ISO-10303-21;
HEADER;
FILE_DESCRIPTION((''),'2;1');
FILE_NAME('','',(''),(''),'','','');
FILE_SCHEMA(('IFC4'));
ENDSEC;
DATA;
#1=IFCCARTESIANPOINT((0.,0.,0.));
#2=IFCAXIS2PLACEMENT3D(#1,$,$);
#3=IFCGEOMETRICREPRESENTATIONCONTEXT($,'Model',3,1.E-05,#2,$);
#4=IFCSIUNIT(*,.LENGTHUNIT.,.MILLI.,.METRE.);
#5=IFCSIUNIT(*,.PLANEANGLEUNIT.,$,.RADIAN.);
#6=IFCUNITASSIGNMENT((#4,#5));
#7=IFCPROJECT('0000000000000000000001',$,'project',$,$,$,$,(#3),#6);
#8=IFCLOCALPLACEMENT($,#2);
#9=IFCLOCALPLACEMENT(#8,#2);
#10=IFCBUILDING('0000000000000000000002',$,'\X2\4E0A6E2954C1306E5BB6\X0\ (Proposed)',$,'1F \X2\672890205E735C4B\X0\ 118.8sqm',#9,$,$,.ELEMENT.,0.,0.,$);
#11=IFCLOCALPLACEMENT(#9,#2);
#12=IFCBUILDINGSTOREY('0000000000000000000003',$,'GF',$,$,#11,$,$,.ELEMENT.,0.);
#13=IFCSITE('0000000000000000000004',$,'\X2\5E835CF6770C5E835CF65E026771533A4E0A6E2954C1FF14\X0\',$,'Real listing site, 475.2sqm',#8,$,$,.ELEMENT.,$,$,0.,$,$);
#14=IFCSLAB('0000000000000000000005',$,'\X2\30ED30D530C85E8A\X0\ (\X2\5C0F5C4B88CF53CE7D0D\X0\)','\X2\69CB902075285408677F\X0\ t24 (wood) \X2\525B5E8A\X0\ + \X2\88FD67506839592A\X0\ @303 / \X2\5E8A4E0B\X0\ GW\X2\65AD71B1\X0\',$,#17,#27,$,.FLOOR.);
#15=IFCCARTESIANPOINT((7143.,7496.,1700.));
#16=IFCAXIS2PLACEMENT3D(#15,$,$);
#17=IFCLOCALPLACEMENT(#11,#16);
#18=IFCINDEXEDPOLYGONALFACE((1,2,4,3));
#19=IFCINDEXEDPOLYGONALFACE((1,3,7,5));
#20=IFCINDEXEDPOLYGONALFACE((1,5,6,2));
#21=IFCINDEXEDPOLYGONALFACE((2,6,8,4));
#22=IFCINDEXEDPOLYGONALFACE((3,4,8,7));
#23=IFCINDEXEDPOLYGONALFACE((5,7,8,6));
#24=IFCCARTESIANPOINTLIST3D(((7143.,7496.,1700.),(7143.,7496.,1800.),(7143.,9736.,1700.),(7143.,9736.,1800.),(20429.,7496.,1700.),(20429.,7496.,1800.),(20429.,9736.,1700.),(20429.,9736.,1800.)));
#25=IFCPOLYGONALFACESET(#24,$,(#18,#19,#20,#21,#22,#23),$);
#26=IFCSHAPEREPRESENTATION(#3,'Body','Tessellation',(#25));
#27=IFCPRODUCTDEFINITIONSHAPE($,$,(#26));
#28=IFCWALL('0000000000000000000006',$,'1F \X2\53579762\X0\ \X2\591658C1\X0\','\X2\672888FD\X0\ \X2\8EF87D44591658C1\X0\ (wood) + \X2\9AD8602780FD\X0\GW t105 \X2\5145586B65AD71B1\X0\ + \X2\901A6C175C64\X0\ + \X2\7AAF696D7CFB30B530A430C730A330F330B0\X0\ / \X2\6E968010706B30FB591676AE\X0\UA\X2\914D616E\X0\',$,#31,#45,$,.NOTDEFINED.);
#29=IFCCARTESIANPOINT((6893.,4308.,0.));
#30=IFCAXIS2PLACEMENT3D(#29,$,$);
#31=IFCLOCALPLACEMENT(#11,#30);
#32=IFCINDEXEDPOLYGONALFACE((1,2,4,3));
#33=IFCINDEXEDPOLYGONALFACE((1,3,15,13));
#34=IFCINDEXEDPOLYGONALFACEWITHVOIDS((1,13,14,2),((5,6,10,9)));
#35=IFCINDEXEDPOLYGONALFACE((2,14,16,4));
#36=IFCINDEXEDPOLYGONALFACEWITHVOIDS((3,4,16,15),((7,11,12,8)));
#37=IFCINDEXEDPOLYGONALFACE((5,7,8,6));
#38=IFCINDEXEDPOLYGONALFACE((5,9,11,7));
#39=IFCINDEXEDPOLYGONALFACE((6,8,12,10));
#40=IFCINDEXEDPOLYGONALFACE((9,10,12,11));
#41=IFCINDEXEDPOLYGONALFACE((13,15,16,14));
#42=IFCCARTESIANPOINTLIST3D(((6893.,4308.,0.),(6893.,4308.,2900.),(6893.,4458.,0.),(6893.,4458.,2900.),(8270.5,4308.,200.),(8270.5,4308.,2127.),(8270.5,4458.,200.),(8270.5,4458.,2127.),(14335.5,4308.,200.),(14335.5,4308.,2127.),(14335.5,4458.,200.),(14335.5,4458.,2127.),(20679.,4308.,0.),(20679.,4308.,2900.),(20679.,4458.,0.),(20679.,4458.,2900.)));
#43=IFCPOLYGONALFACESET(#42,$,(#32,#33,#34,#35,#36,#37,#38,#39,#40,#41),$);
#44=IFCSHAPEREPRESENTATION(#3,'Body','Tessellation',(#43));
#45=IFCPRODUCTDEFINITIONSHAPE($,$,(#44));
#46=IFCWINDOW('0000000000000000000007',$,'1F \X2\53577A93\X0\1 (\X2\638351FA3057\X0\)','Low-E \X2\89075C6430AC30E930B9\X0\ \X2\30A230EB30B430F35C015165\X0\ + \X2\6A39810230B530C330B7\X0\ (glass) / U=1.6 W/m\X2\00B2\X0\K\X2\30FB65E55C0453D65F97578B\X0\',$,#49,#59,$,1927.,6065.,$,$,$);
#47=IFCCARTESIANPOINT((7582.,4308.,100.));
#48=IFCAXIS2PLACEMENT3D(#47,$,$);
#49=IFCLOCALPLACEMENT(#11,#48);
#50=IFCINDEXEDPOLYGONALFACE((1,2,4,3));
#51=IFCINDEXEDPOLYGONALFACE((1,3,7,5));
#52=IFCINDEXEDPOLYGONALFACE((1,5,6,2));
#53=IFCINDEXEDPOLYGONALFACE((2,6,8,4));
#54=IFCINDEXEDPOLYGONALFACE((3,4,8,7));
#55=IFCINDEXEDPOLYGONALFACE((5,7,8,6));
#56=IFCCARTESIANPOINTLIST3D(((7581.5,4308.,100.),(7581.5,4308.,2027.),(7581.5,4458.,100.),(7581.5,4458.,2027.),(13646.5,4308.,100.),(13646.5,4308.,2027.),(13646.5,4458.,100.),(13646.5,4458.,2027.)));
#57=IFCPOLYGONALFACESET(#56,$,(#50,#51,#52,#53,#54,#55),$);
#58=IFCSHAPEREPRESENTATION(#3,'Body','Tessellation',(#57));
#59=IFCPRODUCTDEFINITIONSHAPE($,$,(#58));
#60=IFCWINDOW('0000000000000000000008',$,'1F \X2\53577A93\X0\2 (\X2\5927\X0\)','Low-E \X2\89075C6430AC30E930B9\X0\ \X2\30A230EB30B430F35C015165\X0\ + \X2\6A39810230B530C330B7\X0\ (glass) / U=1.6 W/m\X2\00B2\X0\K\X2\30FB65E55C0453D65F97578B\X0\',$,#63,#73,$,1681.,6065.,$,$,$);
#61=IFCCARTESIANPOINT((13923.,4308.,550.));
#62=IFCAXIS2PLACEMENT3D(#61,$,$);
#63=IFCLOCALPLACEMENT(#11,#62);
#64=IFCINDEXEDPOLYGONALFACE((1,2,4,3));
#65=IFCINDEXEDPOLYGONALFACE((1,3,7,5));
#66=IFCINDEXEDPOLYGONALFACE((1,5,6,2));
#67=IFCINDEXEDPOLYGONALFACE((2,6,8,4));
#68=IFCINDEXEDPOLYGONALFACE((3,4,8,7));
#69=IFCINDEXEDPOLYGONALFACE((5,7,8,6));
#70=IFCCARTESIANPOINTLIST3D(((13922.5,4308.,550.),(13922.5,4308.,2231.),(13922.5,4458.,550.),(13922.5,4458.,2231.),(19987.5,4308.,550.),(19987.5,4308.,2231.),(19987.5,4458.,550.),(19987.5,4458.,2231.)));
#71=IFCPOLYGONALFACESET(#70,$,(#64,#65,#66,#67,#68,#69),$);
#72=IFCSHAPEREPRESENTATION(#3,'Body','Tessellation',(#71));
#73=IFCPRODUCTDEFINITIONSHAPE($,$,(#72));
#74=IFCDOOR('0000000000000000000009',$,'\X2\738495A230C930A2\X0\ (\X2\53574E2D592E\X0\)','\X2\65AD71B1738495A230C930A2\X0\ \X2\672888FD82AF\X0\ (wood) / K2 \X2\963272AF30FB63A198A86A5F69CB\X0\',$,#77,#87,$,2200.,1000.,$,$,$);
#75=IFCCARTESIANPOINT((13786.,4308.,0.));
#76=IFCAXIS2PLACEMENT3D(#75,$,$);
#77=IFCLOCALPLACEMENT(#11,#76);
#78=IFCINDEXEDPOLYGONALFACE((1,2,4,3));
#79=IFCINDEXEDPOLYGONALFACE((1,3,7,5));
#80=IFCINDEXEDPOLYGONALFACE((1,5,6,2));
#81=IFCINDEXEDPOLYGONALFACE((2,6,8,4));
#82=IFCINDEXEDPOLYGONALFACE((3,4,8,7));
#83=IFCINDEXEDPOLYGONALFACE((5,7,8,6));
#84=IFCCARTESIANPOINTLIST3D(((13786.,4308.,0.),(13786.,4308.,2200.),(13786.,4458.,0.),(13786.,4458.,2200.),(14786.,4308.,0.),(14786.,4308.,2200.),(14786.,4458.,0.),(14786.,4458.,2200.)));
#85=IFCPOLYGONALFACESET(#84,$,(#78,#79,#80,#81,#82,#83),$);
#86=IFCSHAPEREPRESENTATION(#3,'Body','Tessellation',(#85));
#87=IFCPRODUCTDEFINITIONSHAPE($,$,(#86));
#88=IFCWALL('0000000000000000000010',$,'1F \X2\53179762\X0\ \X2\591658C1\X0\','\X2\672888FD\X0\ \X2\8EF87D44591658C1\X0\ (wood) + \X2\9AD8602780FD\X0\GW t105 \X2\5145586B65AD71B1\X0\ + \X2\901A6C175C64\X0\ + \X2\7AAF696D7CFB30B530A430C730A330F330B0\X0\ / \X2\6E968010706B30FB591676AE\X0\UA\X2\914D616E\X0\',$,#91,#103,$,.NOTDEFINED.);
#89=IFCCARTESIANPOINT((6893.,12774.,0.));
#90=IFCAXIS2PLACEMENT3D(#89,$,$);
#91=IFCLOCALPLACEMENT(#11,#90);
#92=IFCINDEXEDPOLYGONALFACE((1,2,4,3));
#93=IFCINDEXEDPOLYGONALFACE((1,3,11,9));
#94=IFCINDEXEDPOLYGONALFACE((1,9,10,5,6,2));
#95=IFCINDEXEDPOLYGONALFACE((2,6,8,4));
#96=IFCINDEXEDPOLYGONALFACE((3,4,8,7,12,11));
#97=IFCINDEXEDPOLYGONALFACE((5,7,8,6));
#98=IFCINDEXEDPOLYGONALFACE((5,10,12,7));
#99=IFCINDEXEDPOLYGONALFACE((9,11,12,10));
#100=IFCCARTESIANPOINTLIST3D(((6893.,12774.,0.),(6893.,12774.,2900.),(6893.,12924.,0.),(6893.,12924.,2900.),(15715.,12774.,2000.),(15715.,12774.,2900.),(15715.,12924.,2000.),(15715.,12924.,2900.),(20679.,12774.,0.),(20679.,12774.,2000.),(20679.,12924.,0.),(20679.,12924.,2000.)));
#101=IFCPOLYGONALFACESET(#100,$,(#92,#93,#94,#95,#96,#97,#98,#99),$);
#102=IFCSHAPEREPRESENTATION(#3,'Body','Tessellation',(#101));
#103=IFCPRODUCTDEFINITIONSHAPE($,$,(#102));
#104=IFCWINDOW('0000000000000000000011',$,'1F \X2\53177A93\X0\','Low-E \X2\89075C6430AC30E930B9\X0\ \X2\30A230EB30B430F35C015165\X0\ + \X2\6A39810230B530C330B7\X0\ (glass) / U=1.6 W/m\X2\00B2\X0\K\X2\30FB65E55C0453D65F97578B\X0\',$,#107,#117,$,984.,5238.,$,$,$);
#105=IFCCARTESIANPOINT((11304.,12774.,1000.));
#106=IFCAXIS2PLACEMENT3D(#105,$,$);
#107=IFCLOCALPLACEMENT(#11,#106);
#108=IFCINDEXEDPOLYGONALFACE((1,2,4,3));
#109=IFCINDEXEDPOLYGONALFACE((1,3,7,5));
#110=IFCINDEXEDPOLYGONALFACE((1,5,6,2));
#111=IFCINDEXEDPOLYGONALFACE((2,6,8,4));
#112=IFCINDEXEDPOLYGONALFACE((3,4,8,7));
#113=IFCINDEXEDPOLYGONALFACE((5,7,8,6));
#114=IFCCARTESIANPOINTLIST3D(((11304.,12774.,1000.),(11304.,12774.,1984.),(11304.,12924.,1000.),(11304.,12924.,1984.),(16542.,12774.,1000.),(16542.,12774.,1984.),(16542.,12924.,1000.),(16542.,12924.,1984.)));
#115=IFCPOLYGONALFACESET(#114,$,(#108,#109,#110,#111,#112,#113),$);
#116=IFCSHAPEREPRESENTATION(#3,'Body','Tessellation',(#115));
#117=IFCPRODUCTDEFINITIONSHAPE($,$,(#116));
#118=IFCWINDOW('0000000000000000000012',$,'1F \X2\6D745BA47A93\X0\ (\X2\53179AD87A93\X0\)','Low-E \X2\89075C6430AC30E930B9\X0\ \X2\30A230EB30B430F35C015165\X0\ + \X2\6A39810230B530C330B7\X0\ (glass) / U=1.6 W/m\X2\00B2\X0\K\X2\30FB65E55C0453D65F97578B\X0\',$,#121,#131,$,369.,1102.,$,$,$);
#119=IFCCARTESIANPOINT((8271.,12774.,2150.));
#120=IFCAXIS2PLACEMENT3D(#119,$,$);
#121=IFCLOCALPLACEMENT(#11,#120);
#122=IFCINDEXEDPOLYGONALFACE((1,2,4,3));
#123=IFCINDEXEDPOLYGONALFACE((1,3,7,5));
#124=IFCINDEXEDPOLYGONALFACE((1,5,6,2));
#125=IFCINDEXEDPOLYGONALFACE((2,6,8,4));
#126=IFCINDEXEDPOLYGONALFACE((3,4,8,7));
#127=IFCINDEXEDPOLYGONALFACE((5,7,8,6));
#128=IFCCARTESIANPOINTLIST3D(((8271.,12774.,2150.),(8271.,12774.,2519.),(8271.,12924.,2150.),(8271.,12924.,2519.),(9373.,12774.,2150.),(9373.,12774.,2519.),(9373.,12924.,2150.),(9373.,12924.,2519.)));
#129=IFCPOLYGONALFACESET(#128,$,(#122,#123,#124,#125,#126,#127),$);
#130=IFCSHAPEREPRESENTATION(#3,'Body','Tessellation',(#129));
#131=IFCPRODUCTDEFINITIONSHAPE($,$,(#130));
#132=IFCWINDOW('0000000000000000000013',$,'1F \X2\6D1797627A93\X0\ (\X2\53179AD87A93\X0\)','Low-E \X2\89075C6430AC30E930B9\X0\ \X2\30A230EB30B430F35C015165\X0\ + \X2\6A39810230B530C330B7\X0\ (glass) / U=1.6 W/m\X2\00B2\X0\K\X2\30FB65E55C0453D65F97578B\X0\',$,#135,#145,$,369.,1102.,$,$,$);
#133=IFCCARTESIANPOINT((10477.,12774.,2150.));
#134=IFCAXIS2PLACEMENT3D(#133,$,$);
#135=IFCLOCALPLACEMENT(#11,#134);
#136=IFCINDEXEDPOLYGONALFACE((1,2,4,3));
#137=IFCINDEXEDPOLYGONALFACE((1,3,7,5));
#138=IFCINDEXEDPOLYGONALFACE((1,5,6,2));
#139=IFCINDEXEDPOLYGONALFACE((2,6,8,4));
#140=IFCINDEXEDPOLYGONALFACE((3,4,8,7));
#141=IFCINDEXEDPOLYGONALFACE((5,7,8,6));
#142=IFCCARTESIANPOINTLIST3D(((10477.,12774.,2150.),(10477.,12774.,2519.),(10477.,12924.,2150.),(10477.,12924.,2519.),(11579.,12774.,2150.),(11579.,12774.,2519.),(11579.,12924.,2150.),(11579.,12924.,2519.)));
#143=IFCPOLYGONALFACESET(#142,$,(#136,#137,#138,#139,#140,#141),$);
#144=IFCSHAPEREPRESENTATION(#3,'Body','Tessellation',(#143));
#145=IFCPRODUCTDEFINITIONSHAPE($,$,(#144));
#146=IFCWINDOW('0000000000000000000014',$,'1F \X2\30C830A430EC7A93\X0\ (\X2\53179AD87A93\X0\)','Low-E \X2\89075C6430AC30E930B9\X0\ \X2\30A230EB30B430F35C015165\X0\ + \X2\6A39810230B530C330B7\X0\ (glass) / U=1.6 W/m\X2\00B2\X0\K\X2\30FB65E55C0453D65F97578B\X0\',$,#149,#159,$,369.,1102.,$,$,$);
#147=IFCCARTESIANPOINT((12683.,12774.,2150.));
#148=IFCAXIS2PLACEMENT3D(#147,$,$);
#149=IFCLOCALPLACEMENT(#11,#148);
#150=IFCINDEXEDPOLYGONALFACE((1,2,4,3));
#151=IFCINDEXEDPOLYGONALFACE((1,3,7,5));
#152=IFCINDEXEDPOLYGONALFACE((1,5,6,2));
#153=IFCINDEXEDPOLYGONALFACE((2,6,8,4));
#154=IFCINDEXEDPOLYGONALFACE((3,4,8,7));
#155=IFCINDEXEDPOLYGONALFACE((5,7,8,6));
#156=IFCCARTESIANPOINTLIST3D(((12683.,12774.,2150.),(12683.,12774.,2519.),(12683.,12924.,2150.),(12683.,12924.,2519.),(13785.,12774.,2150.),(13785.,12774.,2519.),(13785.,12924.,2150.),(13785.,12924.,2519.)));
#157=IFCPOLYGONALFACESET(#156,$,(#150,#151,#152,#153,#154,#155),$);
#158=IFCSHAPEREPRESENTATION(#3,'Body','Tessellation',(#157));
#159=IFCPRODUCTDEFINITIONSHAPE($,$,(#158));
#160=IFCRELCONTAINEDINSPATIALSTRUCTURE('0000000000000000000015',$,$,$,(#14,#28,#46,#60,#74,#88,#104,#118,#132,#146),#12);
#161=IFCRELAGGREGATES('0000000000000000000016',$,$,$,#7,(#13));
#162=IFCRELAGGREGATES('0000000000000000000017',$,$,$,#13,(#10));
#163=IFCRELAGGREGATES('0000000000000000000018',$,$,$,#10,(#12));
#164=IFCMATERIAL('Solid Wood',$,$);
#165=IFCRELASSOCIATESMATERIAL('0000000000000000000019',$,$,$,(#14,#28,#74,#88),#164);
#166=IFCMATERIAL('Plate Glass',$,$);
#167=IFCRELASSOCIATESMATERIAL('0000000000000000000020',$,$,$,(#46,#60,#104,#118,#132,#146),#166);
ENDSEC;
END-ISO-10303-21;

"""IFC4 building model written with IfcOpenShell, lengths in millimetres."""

from ifc_helpers import new_model, si_unit, frame, frame_2d, origin, place, context, project, spatial, rectangle, extrude, material, element, fill, save


model = new_model("IFC4")

# Units and contexts
model_context = context("Model", 3, precision=1e-05, world=origin())
ifc_project = project(units=[si_unit("LENGTHUNIT", "METRE", prefix="MILLI"), si_unit("PLANEANGLEUNIT", "RADIAN")], contexts=[model_context])

# Site, building, storey
site_placement = place(None, origin())
site = spatial("IfcSite", under=ifc_project, at=site_placement, Name="広島県広島市東区上温品４", ObjectType="Real listing site, 475.2sqm", CompositionType="ELEMENT", RefElevation=0.0)
building_placement = place(site_placement, origin())
building = spatial("IfcBuilding", under=site, at=building_placement, Name="上温品の家 (Proposed)", ObjectType="1F 木造平屋 118.8sqm", CompositionType="ELEMENT", ElevationOfRefHeight=0.0, ElevationOfTerrain=0.0)
storey_placement = place(building_placement, origin())
storey = spatial("IfcBuildingStorey", under=building, at=storey_placement, Name="GF", CompositionType="ELEMENT", Elevation=0.0)

# Slab
ifc_material_1 = material(Name="Solid Wood")
slab_1_placement = place(storey_placement, frame((7143.0, 7496.0, 1700.0)))
element("IfcSlab", 1, at=slab_1_placement, inside=storey, material=ifc_material_1, Name="ロフト床 (小屋裏収納)", Description="構造用合板 t24 (wood) 剛床 + 製材根太 @303 / 床下 GW断熱", PredefinedType="FLOOR", context=model_context, shape_type="SweptSolid", body=[
    extrude(rectangle(XDim=13286.0, YDim=2240.0, at=frame_2d((6643.0, 1120.0))), frame((7143.0, 7496.0, 1700.0)), (0.0, 0.0, 1.0), 100.0),
])

# Wall, openings, windows, door
wall_1_placement = place(storey_placement, frame((6893.0, 4308.0, 0.0)))
wall_1 = element("IfcWall", 2, at=wall_1_placement, inside=storey, material=ifc_material_1, Name="1F 南面 外壁", Description="木製 軸組外壁 (wood) + 高性能GW t105 充填断熱 + 通気層 + 窯業系サイディング / 準耐火・外皮UA配慮", PredefinedType="NOTDEFINED", context=model_context, shape_type="SweptSolid", body=[
    extrude(rectangle(XDim=13786.0, YDim=150.0, at=frame_2d((6893.0, 75.0))), frame((6893.0, 4308.0, 0.0)), (0.0, 0.0, 1.0), 2900.0),
])
opening_1_placement = place(storey_placement, frame((7582.0, 4308.0, 100.0)))
opening_1 = element("IfcOpeningElement", 3, at=opening_1_placement, cuts=wall_1, PredefinedType="NOTDEFINED", context=model_context, shape_type="SweptSolid", body=[
    extrude(rectangle(XDim=6065.0, YDim=150.0, at=frame_2d((3032.0, 75.0))), frame((7582.0, 4308.0, 100.0)), (0.0, 0.0, 1.0), 1927.0),
])
opening_2_placement = place(storey_placement, frame((13923.0, 4308.0, 550.0)))
opening_2 = element("IfcOpeningElement", 4, at=opening_2_placement, cuts=wall_1, PredefinedType="NOTDEFINED", context=model_context, shape_type="SweptSolid", body=[
    extrude(rectangle(XDim=6065.0, YDim=150.0, at=frame_2d((3032.0, 75.0))), frame((13923.0, 4308.0, 550.0)), (0.0, 0.0, 1.0), 1681.0),
])
opening_3_placement = place(storey_placement, frame((13786.0, 4308.0, 0.0)))
opening_3 = element("IfcOpeningElement", 5, at=opening_3_placement, cuts=wall_1, PredefinedType="NOTDEFINED", context=model_context, shape_type="SweptSolid", body=[
    extrude(rectangle(XDim=1000.0, YDim=150.0, at=frame_2d((500.0, 75.0))), frame((13786.0, 4308.0, 0.0)), (0.0, 0.0, 1.0), 2200.0),
])
ifc_material_2 = material(Name="Plate Glass")
window_1_placement = place(storey_placement, frame((7582.0, 4308.0, 100.0)))
window_1 = element("IfcWindow", 6, at=window_1_placement, inside=storey, material=ifc_material_2, Name="1F 南窓1 (掃出し)", Description="Low-E 複層ガラス アルゴン封入 + 樹脂サッシ (glass) / U=1.6 W/m²K・日射取得型", OverallHeight=1927.0, OverallWidth=6065.0, context=model_context, shape_type="SweptSolid", body=[
    extrude(rectangle(XDim=6065.0, YDim=150.0, at=frame_2d((3032.0, 75.0))), frame((7582.0, 4308.0, 100.0)), (0.0, 0.0, 1.0), 1927.0),
])
fill(opening_1, window_1)
window_2_placement = place(storey_placement, frame((13923.0, 4308.0, 550.0)))
window_2 = element("IfcWindow", 7, at=window_2_placement, inside=storey, material=ifc_material_2, Name="1F 南窓2 (大)", Description="Low-E 複層ガラス アルゴン封入 + 樹脂サッシ (glass) / U=1.6 W/m²K・日射取得型", OverallHeight=1681.0, OverallWidth=6065.0, context=model_context, shape_type="SweptSolid", body=[
    extrude(rectangle(XDim=6065.0, YDim=150.0, at=frame_2d((3032.0, 75.0))), frame((13923.0, 4308.0, 550.0)), (0.0, 0.0, 1.0), 1681.0),
])
fill(opening_2, window_2)
door_1_placement = place(storey_placement, frame((13786.0, 4308.0, 0.0)))
door_1 = element("IfcDoor", 8, at=door_1_placement, inside=storey, material=ifc_material_1, Name="玄関ドア (南中央)", Description="断熱玄関ドア 木製芯 (wood) / K2 防犯・採風機構", OverallHeight=2200.0, OverallWidth=1000.0, context=model_context, shape_type="SweptSolid", body=[
    extrude(rectangle(XDim=1000.0, YDim=150.0, at=frame_2d((500.0, 75.0))), frame((13786.0, 4308.0, 0.0)), (0.0, 0.0, 1.0), 2200.0),
])
fill(opening_3, door_1)

# Wall, openings, windows
wall_2_placement = place(storey_placement, frame((6893.0, 12774.0, 0.0)))
wall_2 = element("IfcWall", 9, at=wall_2_placement, inside=storey, material=ifc_material_1, Name="1F 北面 外壁", Description="木製 軸組外壁 (wood) + 高性能GW t105 充填断熱 + 通気層 + 窯業系サイディング / 準耐火・外皮UA配慮", PredefinedType="NOTDEFINED", context=model_context, shape_type="SweptSolid", body=[
    extrude(rectangle(XDim=13786.0, YDim=150.0, at=frame_2d((6893.0, 75.0))), frame((6893.0, 12774.0, 0.0)), (0.0, 0.0, 1.0), 2900.0),
])
opening_4_placement = place(storey_placement, frame((11304.0, 12774.0, 1000.0)))
opening_4 = element("IfcOpeningElement", 10, at=opening_4_placement, cuts=wall_2, PredefinedType="NOTDEFINED", context=model_context, shape_type="SweptSolid", body=[
    extrude(rectangle(XDim=5238.0, YDim=150.0, at=frame_2d((2619.0, 75.0))), frame((11304.0, 12774.0, 1000.0)), (0.0, 0.0, 1.0), 984.0),
])
opening_5_placement = place(storey_placement, frame((8271.0, 12774.0, 2150.0)))
opening_5 = element("IfcOpeningElement", 11, at=opening_5_placement, cuts=wall_2, PredefinedType="NOTDEFINED", context=model_context, shape_type="SweptSolid", body=[
    extrude(rectangle(XDim=1102.0, YDim=150.0, at=frame_2d((551.0, 75.0))), frame((8271.0, 12774.0, 2150.0)), (0.0, 0.0, 1.0), 369.0),
])
opening_6_placement = place(storey_placement, frame((10477.0, 12774.0, 2150.0)))
opening_6 = element("IfcOpeningElement", 12, at=opening_6_placement, cuts=wall_2, PredefinedType="NOTDEFINED", context=model_context, shape_type="SweptSolid", body=[
    extrude(rectangle(XDim=1102.0, YDim=150.0, at=frame_2d((551.0, 75.0))), frame((10477.0, 12774.0, 2150.0)), (0.0, 0.0, 1.0), 369.0),
])
opening_7_placement = place(storey_placement, frame((12683.0, 12774.0, 2150.0)))
opening_7 = element("IfcOpeningElement", 13, at=opening_7_placement, cuts=wall_2, PredefinedType="NOTDEFINED", context=model_context, shape_type="SweptSolid", body=[
    extrude(rectangle(XDim=1102.0, YDim=150.0, at=frame_2d((551.0, 75.0))), frame((12683.0, 12774.0, 2150.0)), (0.0, 0.0, 1.0), 369.0),
])
window_3_placement = place(storey_placement, frame((11304.0, 12774.0, 1000.0)))
window_3 = element("IfcWindow", 14, at=window_3_placement, inside=storey, material=ifc_material_2, Name="1F 北窓", Description="Low-E 複層ガラス アルゴン封入 + 樹脂サッシ (glass) / U=1.6 W/m²K・日射取得型", OverallHeight=984.0, OverallWidth=5238.0, context=model_context, shape_type="SweptSolid", body=[
    extrude(rectangle(XDim=5238.0, YDim=150.0, at=frame_2d((2619.0, 75.0))), frame((11304.0, 12774.0, 1000.0)), (0.0, 0.0, 1.0), 984.0),
])
fill(opening_4, window_3)
window_4_placement = place(storey_placement, frame((8271.0, 12774.0, 2150.0)))
window_4 = element("IfcWindow", 15, at=window_4_placement, inside=storey, material=ifc_material_2, Name="1F 浴室窓 (北高窓)", Description="Low-E 複層ガラス アルゴン封入 + 樹脂サッシ (glass) / U=1.6 W/m²K・日射取得型", OverallHeight=369.0, OverallWidth=1102.0, context=model_context, shape_type="SweptSolid", body=[
    extrude(rectangle(XDim=1102.0, YDim=150.0, at=frame_2d((551.0, 75.0))), frame((8271.0, 12774.0, 2150.0)), (0.0, 0.0, 1.0), 369.0),
])
fill(opening_5, window_4)
window_5_placement = place(storey_placement, frame((10477.0, 12774.0, 2150.0)))
window_5 = element("IfcWindow", 16, at=window_5_placement, inside=storey, material=ifc_material_2, Name="1F 洗面窓 (北高窓)", Description="Low-E 複層ガラス アルゴン封入 + 樹脂サッシ (glass) / U=1.6 W/m²K・日射取得型", OverallHeight=369.0, OverallWidth=1102.0, context=model_context, shape_type="SweptSolid", body=[
    extrude(rectangle(XDim=1102.0, YDim=150.0, at=frame_2d((551.0, 75.0))), frame((10477.0, 12774.0, 2150.0)), (0.0, 0.0, 1.0), 369.0),
])
fill(opening_6, window_5)
window_6_placement = place(storey_placement, frame((12683.0, 12774.0, 2150.0)))
window_6 = element("IfcWindow", 17, at=window_6_placement, inside=storey, material=ifc_material_2, Name="1F トイレ窓 (北高窓)", Description="Low-E 複層ガラス アルゴン封入 + 樹脂サッシ (glass) / U=1.6 W/m²K・日射取得型", OverallHeight=369.0, OverallWidth=1102.0, context=model_context, shape_type="SweptSolid", body=[
    extrude(rectangle(XDim=1102.0, YDim=150.0, at=frame_2d((551.0, 75.0))), frame((12683.0, 12774.0, 2150.0)), (0.0, 0.0, 1.0), 369.0),
])
fill(opening_7, window_6)

save(model, "model.ifc")
